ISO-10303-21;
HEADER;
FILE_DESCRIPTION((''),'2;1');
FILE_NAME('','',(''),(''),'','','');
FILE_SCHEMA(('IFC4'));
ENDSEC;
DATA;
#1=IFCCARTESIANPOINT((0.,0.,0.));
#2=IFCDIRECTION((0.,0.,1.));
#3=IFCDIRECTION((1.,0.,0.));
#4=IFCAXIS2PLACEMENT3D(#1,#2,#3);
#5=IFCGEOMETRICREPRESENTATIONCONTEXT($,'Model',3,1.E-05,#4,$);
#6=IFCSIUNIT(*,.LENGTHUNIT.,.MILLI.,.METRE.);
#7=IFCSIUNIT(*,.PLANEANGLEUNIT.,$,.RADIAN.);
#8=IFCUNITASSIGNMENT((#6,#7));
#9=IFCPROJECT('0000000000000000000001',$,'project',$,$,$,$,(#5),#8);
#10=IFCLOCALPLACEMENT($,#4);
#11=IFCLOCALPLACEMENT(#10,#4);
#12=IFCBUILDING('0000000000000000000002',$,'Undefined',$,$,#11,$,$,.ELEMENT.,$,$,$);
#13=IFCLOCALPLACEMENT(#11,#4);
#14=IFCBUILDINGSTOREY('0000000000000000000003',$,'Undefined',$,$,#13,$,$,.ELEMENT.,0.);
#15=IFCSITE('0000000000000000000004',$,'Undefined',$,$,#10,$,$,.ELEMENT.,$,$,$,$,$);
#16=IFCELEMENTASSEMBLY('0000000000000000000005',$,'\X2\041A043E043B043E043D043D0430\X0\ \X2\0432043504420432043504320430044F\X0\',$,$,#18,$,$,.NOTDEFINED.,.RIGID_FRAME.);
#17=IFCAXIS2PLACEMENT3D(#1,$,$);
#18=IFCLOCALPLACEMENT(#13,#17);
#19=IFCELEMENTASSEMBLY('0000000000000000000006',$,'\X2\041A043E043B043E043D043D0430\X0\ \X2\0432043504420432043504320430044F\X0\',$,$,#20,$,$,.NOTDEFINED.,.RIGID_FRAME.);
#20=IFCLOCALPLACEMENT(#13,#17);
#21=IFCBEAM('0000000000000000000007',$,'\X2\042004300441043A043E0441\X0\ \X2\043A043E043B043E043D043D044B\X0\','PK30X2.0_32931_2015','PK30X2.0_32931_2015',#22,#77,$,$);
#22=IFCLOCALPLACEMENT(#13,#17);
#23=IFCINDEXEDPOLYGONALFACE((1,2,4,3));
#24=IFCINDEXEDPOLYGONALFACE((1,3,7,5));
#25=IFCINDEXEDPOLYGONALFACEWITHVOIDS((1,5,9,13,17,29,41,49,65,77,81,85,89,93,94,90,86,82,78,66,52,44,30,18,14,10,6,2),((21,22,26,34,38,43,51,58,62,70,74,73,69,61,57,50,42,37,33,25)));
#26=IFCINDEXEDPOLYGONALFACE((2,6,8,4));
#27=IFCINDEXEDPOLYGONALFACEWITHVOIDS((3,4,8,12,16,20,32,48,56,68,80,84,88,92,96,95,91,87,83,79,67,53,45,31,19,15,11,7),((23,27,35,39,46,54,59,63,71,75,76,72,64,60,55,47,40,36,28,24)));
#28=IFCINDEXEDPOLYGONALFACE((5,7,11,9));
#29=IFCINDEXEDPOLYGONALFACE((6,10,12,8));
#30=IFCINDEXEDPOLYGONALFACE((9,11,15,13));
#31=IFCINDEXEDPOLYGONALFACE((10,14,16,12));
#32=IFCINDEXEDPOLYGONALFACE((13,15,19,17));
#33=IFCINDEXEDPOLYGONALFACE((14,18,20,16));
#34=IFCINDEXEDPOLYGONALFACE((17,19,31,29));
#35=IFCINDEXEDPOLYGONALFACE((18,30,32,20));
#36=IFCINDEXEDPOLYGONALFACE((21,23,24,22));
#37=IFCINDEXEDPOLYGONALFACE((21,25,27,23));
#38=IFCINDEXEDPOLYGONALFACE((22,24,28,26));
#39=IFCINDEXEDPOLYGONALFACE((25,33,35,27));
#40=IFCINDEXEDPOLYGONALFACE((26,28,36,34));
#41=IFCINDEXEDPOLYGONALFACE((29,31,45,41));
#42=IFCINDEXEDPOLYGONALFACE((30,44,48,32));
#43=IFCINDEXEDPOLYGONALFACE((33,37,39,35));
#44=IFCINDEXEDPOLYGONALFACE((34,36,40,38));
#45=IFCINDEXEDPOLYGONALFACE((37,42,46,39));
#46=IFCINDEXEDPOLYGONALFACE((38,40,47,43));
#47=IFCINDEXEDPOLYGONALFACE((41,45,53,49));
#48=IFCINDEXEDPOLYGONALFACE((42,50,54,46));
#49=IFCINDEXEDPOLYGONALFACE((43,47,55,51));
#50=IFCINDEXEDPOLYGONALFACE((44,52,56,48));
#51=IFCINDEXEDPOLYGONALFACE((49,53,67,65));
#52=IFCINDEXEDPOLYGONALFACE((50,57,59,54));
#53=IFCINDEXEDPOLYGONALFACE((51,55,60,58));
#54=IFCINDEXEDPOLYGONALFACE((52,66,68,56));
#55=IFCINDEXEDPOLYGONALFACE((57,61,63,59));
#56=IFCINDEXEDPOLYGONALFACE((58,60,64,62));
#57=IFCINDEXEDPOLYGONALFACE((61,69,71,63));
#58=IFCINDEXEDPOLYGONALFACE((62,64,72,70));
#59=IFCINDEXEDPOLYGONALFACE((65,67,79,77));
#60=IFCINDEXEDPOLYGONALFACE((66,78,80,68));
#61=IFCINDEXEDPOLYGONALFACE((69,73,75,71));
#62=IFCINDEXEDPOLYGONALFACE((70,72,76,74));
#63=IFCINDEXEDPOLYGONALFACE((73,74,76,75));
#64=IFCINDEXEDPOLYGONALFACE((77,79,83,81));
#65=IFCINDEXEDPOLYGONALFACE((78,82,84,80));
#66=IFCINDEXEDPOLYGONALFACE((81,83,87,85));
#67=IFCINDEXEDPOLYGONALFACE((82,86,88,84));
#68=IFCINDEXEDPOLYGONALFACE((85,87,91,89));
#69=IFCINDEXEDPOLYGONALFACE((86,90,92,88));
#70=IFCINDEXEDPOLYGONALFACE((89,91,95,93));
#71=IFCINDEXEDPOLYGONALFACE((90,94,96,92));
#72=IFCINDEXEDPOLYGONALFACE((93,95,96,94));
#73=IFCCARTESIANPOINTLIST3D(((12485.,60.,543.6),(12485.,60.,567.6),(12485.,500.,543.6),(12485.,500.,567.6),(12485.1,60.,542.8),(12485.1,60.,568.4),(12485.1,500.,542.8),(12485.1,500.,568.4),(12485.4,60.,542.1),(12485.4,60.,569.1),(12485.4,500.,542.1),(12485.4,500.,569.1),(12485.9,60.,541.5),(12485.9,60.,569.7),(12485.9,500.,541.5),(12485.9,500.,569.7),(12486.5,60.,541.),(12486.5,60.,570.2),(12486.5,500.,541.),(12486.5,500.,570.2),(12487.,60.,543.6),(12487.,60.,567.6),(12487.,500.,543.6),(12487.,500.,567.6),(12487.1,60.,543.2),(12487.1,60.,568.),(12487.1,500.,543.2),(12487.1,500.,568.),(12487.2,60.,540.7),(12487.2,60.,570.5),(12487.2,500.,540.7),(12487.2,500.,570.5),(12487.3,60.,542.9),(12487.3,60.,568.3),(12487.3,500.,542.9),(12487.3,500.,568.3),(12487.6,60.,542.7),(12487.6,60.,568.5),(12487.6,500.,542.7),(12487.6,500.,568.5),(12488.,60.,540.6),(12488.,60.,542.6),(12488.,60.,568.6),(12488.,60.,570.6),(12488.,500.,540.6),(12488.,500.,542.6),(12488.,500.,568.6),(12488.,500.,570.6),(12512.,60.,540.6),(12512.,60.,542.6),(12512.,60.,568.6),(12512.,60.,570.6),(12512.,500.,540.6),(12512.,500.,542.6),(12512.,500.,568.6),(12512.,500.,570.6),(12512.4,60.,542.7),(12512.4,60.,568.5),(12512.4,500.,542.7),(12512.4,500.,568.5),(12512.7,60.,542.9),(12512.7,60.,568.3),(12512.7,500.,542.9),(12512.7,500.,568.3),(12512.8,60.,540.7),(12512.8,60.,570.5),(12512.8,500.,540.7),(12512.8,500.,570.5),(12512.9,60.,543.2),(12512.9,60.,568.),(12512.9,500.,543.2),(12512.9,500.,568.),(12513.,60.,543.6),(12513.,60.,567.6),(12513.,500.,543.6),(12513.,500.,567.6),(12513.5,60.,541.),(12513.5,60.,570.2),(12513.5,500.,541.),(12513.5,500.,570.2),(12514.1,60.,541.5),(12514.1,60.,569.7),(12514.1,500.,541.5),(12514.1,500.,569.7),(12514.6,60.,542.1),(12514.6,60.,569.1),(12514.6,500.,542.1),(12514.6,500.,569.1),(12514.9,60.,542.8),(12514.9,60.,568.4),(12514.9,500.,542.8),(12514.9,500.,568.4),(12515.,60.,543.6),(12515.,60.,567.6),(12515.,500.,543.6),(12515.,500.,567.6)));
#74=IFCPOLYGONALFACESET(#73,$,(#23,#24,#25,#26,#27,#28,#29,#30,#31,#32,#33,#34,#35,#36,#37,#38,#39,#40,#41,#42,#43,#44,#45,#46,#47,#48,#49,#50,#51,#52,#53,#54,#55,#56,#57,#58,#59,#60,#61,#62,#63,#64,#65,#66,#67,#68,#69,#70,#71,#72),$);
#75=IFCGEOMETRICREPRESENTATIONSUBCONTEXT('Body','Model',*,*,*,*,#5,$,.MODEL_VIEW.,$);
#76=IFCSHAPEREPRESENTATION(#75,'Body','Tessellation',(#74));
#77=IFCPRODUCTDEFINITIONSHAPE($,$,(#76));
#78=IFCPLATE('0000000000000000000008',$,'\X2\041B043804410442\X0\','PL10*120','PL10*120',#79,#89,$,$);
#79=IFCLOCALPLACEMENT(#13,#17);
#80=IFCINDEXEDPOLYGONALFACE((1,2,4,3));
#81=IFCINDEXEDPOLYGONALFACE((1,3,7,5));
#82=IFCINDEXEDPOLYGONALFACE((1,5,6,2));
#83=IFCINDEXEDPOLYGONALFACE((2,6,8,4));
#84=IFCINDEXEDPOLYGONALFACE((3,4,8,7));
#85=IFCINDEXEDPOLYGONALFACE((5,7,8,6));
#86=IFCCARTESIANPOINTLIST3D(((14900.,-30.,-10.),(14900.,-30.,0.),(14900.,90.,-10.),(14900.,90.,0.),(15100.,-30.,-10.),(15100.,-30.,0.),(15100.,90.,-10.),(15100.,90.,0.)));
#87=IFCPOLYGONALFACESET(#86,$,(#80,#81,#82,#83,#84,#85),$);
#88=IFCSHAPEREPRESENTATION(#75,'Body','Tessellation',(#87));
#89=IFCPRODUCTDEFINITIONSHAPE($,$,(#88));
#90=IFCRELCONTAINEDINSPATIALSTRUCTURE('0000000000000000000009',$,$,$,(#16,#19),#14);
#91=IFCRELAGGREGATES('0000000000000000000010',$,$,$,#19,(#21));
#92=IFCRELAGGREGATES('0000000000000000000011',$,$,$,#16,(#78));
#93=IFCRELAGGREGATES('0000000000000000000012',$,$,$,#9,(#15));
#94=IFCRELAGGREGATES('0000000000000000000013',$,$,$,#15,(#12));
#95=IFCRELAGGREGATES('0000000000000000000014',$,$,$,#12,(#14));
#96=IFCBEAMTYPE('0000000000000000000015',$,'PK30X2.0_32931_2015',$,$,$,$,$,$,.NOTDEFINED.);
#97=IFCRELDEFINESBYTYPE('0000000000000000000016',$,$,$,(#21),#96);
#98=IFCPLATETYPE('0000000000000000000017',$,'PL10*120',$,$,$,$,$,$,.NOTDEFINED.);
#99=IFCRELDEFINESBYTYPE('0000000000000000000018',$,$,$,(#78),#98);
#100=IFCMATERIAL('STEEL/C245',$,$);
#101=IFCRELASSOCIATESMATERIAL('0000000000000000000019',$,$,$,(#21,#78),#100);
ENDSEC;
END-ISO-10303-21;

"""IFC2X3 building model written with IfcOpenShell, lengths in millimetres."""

from ifc_helpers import new_model, si_unit, frame, origin_with_axes, origin_2d_with_axis, place, context, subcontext, project, spatial, polyline, hollow_rectangle, outline, extrude, material, type_object, element, aggregate, save


model = new_model("IFC2X3")

# Units and contexts
model_context = context("Model", 3, precision=1e-05, world=origin_with_axes())
body_context = subcontext(model_context, "Body", "Model", "MODEL_VIEW")
ifc_project = project(units=[si_unit("LENGTHUNIT", "METRE", prefix="MILLI"), si_unit("PLANEANGLEUNIT", "RADIAN")], contexts=[model_context])

# Site, building, storey
site_placement = place(None, origin_with_axes())
site = spatial("IfcSite", under=ifc_project, at=site_placement, Name="Undefined", CompositionType="ELEMENT")
building_placement = place(site_placement, origin_with_axes())
building = spatial("IfcBuilding", under=site, at=building_placement, Name="Undefined", CompositionType="ELEMENT")
storey_placement = place(building_placement, origin_with_axes())
storey = spatial("IfcBuildingStorey", under=building, at=storey_placement, Name="Undefined", CompositionType="ELEMENT", Elevation=0.0)

# Element assemblies
assembly_1_placement = place(storey_placement, origin_with_axes())
assembly_1 = element("IfcElementAssembly", 1, at=assembly_1_placement, inside=storey, Name="Колонна ветвевая", AssemblyPlace="NOTDEFINED", PredefinedType="RIGID_FRAME")
ifc_material_1 = material(Name="STEEL/C245")
assembly_2_placement = place(storey_placement, origin_with_axes())
assembly_2 = element("IfcElementAssembly", 2, at=assembly_2_placement, inside=storey, Name="Колонна ветвевая", AssemblyPlace="NOTDEFINED", PredefinedType="RIGID_FRAME")

# Beam
beam_type_1 = type_object("IfcBeamType", Name="PK30X2.0_32931_2015", PredefinedType="NOTDEFINED")
beam_1_placement = place(assembly_2_placement, frame((12500.0, 500.0, 555.6), z_axis=(0.0, 0.0, 1.0), x_axis=(0.0, -1.0, 0.0)))
beam_1 = element("IfcBeam", 3, at=beam_1_placement, type_object=beam_type_1, material=ifc_material_1, Name="Раскос колонны", Description="PK30X2.0_32931_2015", ObjectType="PK30X2.0_32931_2015", context=body_context, shape_type="SweptSolid", body=[
    extrude(hollow_rectangle(XDim=30.0, YDim=30.0, WallThickness=2.0, InnerFilletRadius=1.0, OuterFilletRadius=3.0, at=origin_2d_with_axis()), frame((440.0, 0.0, 0.0), z_axis=(-1.0, 0.0, 0.0), x_axis=(0.0, -1.0, 0.0)), (0.0, 0.0, 1.0), 440.0),
])
aggregate(assembly_2, [beam_1])

# Plate
plate_type = type_object("IfcPlateType", Name="PL10*120", PredefinedType="NOTDEFINED")
plate_placement = place(assembly_1_placement, frame((14900.0, 90.0, -5.0), z_axis=(0.0, 0.0, -1.0), x_axis=(1.0, 0.0, 0.0)))
plate = element("IfcPlate", 4, at=plate_placement, type_object=plate_type, material=ifc_material_1, Name="Лист", Description="PL10*120", ObjectType="PL10*120", context=body_context, shape_type="SweptSolid", body=[
    extrude(outline(polyline([(0.0, 0.0), (200.0, 0.0), (200.0, 120.0), (0.0, 120.0), (0.0, 0.0)])), frame((0.0, 0.0, -5.0), z_axis=(0.0, 0.0, 1.0), x_axis=(1.0, 0.0, 0.0)), (0.0, 0.0, 1.0), 10.0),
])
aggregate(assembly_1, [plate])

save(model, "model.ifc")
